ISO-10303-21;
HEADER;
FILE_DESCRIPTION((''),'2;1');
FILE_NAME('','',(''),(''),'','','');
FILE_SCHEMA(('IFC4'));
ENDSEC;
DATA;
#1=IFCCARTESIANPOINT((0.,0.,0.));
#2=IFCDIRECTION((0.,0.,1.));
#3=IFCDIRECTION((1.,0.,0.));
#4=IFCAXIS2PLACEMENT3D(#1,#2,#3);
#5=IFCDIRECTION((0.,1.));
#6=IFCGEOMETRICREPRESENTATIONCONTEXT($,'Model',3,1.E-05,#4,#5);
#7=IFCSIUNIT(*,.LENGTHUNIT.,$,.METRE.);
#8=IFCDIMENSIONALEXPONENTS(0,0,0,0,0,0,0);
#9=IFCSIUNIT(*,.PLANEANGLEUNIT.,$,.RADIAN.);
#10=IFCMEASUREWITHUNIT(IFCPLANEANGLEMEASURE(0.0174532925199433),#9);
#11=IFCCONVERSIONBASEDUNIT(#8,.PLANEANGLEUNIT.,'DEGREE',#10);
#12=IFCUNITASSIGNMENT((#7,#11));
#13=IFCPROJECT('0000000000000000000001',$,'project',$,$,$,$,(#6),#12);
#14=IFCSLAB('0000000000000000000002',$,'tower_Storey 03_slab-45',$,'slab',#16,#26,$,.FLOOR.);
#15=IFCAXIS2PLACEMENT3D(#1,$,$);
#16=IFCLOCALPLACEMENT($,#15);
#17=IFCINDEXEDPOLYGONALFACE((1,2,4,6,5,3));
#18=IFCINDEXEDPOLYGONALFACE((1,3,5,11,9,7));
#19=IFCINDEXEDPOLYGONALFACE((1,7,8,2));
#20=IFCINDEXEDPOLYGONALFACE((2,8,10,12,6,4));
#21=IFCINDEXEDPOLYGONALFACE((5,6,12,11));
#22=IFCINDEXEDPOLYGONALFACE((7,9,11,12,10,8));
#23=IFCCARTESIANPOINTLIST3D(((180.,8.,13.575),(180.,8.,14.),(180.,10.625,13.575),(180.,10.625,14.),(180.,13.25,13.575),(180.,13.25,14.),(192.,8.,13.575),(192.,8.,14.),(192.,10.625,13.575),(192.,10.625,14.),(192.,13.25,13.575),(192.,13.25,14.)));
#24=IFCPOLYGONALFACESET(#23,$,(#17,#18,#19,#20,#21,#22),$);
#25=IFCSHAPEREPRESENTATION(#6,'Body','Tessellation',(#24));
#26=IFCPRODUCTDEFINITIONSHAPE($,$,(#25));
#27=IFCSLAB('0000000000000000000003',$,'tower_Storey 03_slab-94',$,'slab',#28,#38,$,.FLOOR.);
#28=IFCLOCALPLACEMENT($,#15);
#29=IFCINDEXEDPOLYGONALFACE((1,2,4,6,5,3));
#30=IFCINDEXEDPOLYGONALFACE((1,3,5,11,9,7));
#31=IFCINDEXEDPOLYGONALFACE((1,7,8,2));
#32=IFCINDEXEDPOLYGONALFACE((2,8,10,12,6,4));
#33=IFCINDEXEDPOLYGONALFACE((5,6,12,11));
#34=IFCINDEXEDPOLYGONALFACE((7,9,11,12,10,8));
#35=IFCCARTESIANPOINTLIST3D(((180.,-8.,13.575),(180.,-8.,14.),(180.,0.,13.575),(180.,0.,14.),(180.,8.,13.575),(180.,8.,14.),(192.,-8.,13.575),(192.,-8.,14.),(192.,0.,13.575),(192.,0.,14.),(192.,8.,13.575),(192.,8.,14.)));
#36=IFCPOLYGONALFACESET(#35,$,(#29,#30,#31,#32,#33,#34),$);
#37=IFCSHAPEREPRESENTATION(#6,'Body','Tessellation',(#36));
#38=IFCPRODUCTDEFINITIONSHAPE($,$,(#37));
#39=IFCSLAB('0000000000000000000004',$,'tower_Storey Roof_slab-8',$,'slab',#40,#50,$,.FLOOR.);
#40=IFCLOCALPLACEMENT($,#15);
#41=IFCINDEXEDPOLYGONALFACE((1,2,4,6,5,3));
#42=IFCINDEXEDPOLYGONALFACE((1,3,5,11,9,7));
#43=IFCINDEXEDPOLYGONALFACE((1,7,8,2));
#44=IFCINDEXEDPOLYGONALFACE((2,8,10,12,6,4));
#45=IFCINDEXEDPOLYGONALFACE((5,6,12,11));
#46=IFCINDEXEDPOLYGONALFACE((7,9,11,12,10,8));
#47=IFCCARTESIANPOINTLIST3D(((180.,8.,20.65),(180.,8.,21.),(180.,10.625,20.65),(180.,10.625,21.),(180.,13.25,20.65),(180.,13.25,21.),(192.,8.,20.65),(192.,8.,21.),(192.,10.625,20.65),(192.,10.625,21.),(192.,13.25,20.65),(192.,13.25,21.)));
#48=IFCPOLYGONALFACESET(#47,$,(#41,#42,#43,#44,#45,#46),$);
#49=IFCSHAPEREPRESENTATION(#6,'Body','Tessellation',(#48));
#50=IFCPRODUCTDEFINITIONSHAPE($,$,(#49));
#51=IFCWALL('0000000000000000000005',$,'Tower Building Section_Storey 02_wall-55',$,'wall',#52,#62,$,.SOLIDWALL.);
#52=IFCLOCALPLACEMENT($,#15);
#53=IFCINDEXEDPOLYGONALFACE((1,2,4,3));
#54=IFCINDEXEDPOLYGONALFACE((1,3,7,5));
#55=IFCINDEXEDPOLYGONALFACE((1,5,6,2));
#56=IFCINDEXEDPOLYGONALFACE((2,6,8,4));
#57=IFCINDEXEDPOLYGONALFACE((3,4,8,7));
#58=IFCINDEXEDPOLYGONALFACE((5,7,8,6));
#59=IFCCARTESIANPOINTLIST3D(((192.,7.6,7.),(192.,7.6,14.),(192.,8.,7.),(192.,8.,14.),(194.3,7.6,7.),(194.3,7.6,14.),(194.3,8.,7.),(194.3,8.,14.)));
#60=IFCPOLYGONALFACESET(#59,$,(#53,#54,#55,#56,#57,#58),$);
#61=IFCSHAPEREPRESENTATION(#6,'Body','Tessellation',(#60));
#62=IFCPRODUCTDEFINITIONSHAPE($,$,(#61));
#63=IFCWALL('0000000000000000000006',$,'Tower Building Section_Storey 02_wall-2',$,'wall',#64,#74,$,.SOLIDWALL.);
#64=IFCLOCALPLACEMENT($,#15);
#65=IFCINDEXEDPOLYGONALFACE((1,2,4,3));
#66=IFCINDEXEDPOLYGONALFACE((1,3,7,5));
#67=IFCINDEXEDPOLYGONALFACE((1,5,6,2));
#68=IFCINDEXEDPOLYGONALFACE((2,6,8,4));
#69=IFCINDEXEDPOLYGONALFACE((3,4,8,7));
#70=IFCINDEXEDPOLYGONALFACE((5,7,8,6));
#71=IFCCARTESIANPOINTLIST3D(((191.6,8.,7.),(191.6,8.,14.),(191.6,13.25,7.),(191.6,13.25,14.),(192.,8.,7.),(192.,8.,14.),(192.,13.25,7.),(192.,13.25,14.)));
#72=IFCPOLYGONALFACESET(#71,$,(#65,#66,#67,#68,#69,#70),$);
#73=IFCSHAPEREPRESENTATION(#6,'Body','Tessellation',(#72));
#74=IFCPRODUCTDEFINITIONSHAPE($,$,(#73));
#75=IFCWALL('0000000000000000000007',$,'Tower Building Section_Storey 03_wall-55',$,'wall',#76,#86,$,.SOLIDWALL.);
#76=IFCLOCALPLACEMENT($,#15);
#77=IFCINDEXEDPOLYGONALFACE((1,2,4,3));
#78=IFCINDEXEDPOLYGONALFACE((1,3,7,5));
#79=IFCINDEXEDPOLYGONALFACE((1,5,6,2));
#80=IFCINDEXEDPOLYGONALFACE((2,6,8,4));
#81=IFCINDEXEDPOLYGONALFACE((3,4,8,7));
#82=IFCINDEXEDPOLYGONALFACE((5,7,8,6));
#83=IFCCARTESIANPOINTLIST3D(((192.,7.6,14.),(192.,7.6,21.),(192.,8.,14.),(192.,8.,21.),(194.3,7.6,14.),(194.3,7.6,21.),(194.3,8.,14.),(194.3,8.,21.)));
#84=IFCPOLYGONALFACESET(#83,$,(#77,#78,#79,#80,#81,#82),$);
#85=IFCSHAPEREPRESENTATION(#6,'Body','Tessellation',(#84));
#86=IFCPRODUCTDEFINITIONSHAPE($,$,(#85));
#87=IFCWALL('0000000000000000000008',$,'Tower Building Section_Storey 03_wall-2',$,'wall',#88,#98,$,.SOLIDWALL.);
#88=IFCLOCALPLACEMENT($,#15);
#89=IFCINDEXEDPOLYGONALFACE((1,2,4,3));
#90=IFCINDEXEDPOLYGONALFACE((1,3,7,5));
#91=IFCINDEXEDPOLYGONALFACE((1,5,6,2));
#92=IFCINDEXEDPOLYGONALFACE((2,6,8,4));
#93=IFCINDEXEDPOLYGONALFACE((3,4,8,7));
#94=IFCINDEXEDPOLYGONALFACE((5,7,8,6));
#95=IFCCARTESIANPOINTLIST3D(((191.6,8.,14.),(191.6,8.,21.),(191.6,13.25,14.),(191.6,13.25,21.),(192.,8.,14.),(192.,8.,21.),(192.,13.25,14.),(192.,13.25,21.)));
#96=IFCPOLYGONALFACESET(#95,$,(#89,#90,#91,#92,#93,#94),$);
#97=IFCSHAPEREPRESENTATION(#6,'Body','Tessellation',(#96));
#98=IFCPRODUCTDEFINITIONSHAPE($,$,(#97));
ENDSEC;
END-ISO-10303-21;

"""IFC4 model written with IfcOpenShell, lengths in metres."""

from ifc_helpers import new_model, entity, si_unit, converted_unit, direction, frame, origin_with_axes, place, context, project, polyline, outline, extrude, element, save


model = new_model("IFC4")

# Units and contexts
model_context = context("Model", 3, precision=1e-05, world=origin_with_axes(), true_north=direction((0.0, 1.0)))
ifc_project = project(units=[si_unit("LENGTHUNIT", "METRE"), converted_unit("PLANEANGLEUNIT", "DEGREE", entity("IfcPlaneAngleMeasure", 0.0174532925199433), si_unit("PLANEANGLEUNIT", "RADIAN"), dimensions=[0, 0, 0, 0, 0, 0, 0])], contexts=[model_context])

# Shared definitions
placement_1 = place(None, origin_with_axes())
placement_2 = place(placement_1, frame((0.0, 0.0, 14.0), z_axis=(0.0, 0.0, 1.0), x_axis=(1.0, 0.0, 0.0)))

# Shared definitions
placement_3 = place(placement_1, frame((0.0, 0.0, 21.0), z_axis=(0.0, 0.0, 1.0), x_axis=(1.0, 0.0, 0.0)))

# Slabs
slab_1_placement = place(placement_2, frame((186.0, 10.625, -0.425), z_axis=(0.0, 0.0, 1.0), x_axis=(1.0, 0.0, 0.0)))
element("IfcSlab", 1, at=slab_1_placement, Name="tower_Storey 03_slab-45", ObjectType="slab", PredefinedType="FLOOR", context=model_context, body=[
    extrude(outline(polyline([(-6.0, -2.625, 0.0), (6.0, -2.625, 0.0), (6.0, 0.0, 0.0), (6.0, 2.625, 0.0), (-6.0, 2.625, 0.0), (-6.0, 0.0, 0.0), (-6.0, -2.625, 0.0)])), origin_with_axes(), (0.0, 0.0, 1.0), 0.425),
])
slab_2_placement = place(placement_2, frame((186.0, 0.0, -0.425), z_axis=(0.0, 0.0, 1.0), x_axis=(1.0, 0.0, 0.0)))
element("IfcSlab", 2, at=slab_2_placement, Name="tower_Storey 03_slab-94", ObjectType="slab", PredefinedType="FLOOR", context=model_context, body=[
    extrude(outline(polyline([(-6.0, -8.0, 0.0), (6.0, -8.0, 0.0), (6.0, 0.0, 0.0), (6.0, 8.0, 0.0), (-6.0, 8.0, 0.0), (-6.0, 0.0, 0.0), (-6.0, -8.0, 0.0)])), origin_with_axes(), (0.0, 0.0, 1.0), 0.425),
])
slab_3_placement = place(placement_3, frame((186.0, 10.625, -0.35), z_axis=(0.0, 0.0, 1.0), x_axis=(1.0, 0.0, 0.0)))
element("IfcSlab", 3, at=slab_3_placement, Name="tower_Storey Roof_slab-8", ObjectType="slab", PredefinedType="FLOOR", context=model_context, body=[
    extrude(outline(polyline([(-6.0, -2.625, 0.0), (6.0, -2.625, 0.0), (6.0, 0.0, 0.0), (6.0, 2.625, 0.0), (-6.0, 2.625, 0.0), (-6.0, 0.0, 0.0), (-6.0, -2.625, 0.0)])), origin_with_axes(), (0.0, 0.0, 1.0), 0.35),
])

# Walls
placement_4 = place(placement_1, frame((0.0, 0.0, 7.0), z_axis=(0.0, 0.0, 1.0), x_axis=(1.0, 0.0, 0.0)))
wall_1_placement = place(placement_4, frame((193.15, 7.6, 3.5), z_axis=(0.0, 1.0, 0.0), x_axis=(0.0, 0.0, 1.0)))
element("IfcWall", 4, at=wall_1_placement, Name="Tower Building Section_Storey 02_wall-55", ObjectType="wall", PredefinedType="SOLIDWALL", context=model_context, body=[
    extrude(outline(polyline([(-3.5, -1.15, 0.0), (3.5, -1.15, 0.0), (3.5, 1.15, 0.0), (-3.5, 1.15, 0.0), (-3.5, -1.15, 0.0)])), origin_with_axes(), (0.0, 0.0, 1.0), 0.4),
])
wall_2_placement = place(placement_4, frame((192.0, 10.625, 3.5), z_axis=(-1.0, 0.0, 0.0), x_axis=(0.0, 0.0, 1.0)))
element("IfcWall", 5, at=wall_2_placement, Name="Tower Building Section_Storey 02_wall-2", ObjectType="wall", PredefinedType="SOLIDWALL", context=model_context, body=[
    extrude(outline(polyline([(-3.5, -2.625, 0.0), (3.5, -2.625, 0.0), (3.5, 2.625, 0.0), (-3.5, 2.625, 0.0), (-3.5, -2.625, 0.0)])), origin_with_axes(), (0.0, 0.0, 1.0), 0.4),
])
wall_3_placement = place(placement_2, frame((193.15, 7.6, 3.5), z_axis=(0.0, 1.0, 0.0), x_axis=(0.0, 0.0, 1.0)))
element("IfcWall", 6, at=wall_3_placement, Name="Tower Building Section_Storey 03_wall-55", ObjectType="wall", PredefinedType="SOLIDWALL", context=model_context, body=[
    extrude(outline(polyline([(-3.5, -1.15, 0.0), (3.5, -1.15, 0.0), (3.5, 1.15, 0.0), (-3.5, 1.15, 0.0), (-3.5, -1.15, 0.0)])), origin_with_axes(), (0.0, 0.0, 1.0), 0.4),
])
wall_4_placement = place(placement_2, frame((192.0, 10.625, 3.5), z_axis=(-1.0, 0.0, 0.0), x_axis=(0.0, 0.0, 1.0)))
element("IfcWall", 7, at=wall_4_placement, Name="Tower Building Section_Storey 03_wall-2", ObjectType="wall", PredefinedType="SOLIDWALL", context=model_context, body=[
    extrude(outline(polyline([(-3.5, -2.625, 0.0), (3.5, -2.625, 0.0), (3.5, 2.625, 0.0), (-3.5, 2.625, 0.0), (-3.5, -2.625, 0.0)])), origin_with_axes(), (0.0, 0.0, 1.0), 0.4),
])

save(model, "model.ifc")
